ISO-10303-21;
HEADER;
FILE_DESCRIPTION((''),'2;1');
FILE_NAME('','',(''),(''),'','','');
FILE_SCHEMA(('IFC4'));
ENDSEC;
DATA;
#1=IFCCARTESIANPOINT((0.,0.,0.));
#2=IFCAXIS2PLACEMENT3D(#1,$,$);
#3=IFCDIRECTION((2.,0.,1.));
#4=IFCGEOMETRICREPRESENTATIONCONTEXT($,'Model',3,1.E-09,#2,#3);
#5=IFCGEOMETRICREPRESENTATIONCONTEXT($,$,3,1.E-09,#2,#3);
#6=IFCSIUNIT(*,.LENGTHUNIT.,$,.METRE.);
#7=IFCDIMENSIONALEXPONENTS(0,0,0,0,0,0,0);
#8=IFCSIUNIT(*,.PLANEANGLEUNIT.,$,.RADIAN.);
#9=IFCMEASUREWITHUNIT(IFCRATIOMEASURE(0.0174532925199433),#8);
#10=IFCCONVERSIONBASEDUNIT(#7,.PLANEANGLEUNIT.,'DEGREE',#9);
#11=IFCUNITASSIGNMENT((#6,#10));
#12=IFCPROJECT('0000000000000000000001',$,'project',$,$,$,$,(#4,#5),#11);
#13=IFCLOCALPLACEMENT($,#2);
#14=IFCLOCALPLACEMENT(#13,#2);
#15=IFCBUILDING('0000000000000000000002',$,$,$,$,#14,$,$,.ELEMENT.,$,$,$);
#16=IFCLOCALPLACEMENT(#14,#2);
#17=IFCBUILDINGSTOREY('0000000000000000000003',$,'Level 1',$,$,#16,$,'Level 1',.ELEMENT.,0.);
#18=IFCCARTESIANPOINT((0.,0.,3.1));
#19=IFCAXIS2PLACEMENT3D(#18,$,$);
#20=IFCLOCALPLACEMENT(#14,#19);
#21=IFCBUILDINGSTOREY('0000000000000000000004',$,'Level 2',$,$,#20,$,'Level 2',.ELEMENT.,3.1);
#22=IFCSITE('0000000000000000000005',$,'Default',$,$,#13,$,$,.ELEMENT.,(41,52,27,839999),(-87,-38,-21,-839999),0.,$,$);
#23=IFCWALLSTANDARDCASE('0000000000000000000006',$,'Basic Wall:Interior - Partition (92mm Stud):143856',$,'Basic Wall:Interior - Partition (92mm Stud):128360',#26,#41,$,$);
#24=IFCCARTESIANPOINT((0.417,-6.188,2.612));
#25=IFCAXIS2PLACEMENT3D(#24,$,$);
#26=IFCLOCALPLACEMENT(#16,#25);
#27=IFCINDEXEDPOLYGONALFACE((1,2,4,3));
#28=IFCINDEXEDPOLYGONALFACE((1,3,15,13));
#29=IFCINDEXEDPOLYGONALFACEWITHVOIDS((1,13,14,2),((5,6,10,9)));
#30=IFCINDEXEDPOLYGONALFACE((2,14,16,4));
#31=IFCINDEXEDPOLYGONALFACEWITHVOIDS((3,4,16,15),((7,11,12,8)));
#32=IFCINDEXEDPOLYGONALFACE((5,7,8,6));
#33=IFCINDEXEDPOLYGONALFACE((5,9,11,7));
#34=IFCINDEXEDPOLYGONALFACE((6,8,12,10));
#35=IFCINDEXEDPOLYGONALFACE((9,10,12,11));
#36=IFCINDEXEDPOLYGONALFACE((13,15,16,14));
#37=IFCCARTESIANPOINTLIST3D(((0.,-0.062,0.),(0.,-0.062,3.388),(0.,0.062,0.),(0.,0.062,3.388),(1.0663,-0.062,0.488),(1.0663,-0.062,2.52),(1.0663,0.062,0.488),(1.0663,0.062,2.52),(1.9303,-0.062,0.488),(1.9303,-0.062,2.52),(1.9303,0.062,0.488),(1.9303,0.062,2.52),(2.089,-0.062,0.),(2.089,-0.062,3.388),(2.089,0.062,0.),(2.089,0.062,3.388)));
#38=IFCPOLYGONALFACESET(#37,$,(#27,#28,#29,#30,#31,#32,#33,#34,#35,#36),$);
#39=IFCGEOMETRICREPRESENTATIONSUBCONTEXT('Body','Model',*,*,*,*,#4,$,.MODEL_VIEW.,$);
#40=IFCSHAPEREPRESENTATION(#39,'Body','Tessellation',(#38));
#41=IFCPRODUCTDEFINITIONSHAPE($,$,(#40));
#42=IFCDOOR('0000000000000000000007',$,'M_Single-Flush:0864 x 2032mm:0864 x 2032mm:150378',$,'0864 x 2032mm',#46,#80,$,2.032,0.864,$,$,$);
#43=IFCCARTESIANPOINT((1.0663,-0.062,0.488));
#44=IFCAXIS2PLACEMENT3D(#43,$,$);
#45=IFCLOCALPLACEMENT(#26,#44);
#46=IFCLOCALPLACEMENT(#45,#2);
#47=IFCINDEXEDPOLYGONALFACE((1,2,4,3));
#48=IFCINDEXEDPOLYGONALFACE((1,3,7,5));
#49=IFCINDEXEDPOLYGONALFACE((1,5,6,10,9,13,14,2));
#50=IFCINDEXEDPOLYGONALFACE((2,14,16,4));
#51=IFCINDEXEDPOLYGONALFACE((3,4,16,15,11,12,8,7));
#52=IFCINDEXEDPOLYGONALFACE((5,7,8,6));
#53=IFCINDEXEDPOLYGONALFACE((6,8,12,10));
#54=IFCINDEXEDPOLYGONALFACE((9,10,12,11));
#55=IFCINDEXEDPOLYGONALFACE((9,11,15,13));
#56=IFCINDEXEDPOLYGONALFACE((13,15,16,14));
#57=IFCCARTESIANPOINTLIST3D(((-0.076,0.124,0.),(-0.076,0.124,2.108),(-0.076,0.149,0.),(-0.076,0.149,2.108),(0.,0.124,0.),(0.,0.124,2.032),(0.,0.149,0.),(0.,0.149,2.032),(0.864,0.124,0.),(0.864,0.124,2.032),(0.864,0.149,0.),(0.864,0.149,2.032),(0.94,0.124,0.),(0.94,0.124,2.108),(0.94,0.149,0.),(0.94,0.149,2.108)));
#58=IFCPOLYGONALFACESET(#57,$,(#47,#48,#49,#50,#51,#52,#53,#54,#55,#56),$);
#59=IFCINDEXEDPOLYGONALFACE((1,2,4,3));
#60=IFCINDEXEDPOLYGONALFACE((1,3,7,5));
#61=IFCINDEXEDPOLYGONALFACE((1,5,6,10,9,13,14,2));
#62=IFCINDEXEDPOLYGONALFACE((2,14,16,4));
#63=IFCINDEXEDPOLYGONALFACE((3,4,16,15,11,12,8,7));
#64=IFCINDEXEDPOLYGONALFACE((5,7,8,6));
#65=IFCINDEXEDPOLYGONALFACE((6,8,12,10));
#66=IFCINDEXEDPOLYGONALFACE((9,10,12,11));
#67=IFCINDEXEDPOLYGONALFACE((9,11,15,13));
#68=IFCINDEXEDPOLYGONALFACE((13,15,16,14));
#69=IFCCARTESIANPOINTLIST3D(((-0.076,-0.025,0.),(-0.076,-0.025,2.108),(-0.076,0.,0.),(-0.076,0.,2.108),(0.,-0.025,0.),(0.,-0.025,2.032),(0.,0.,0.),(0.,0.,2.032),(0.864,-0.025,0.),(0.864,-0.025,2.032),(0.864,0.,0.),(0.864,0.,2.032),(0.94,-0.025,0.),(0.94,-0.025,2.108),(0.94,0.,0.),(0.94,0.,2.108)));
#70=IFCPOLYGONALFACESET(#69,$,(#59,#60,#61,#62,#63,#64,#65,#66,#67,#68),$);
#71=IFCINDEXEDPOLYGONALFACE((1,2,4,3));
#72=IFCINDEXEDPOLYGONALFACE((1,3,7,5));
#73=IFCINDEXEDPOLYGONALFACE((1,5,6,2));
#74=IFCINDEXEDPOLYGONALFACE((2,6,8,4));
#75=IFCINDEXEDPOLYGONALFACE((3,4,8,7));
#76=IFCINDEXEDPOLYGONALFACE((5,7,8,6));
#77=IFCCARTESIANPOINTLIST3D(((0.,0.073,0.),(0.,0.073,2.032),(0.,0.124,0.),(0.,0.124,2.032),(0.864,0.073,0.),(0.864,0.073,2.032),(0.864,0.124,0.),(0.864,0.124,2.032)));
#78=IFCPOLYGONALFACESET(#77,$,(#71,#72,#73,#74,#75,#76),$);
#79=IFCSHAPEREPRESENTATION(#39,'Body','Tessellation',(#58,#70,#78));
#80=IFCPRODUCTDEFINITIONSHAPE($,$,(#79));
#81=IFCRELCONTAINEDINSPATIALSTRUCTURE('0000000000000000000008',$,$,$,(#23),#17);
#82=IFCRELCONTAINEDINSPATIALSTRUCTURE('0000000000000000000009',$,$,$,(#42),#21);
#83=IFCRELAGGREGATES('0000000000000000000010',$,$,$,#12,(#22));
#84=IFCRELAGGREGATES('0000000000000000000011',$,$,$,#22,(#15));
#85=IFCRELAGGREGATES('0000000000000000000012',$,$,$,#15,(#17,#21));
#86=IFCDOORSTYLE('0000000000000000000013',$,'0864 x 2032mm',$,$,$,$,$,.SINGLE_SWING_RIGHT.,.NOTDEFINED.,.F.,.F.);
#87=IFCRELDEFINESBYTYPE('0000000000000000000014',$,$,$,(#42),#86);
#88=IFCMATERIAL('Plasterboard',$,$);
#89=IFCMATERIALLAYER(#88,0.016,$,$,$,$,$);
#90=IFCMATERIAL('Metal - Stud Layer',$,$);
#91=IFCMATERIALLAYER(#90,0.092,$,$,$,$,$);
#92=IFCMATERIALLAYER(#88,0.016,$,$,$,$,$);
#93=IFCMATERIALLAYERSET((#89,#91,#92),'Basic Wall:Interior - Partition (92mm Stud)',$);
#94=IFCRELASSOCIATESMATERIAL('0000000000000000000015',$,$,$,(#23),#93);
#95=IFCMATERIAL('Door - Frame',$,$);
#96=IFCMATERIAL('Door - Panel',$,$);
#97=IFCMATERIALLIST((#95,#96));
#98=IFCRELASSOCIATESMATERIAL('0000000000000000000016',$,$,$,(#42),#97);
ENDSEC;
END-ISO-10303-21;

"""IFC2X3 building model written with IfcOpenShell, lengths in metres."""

from ifc_helpers import new_model, entity, si_unit, converted_unit, direction, frame, frame_2d, origin, origin_2d_with_axis, place, context, subcontext, project, spatial, polyline, rectangle, outline, extrude, source, transform, mapped, material, material_list, layer, layer_set, layer_usage, type_object, type_shapes, element, fill, save


model = new_model("IFC2X3")

# Units and contexts
model_context = context("Model", 3, precision=1e-09, world=origin(), true_north=direction((2.0, 0.0, 1.0)))
context_of_model = context(None, 3, precision=1e-09, world=origin(), true_north=direction((2.0, 0.0, 1.0)))
body_context = subcontext(model_context, "Body", "Model", "MODEL_VIEW")
ifc_project = project(units=[si_unit("LENGTHUNIT", "METRE"), converted_unit("PLANEANGLEUNIT", "DEGREE", entity("IfcRatioMeasure", 0.0174532925199433), si_unit("PLANEANGLEUNIT", "RADIAN"), dimensions=[0, 0, 0, 0, 0, 0, 0])], contexts=[model_context, context_of_model])

# Site, building, storey
site_placement = place(None, origin())
site = spatial("IfcSite", under=ifc_project, at=site_placement, Name="Default", CompositionType="ELEMENT", RefLatitude=(41, 52, 27, 839999), RefLongitude=(-87, -38, -21, -839999), RefElevation=0.0)
building_placement = place(site_placement, origin())
building = spatial("IfcBuilding", under=site, at=building_placement, CompositionType="ELEMENT")
storey_1_placement = place(building_placement, origin())
storey_1 = spatial("IfcBuildingStorey", under=building, at=storey_1_placement, Name="Level 1", LongName="Level 1", CompositionType="ELEMENT", Elevation=0.0)

# Shared definitions
ifc_material_1 = material(Name="Metal - Stud Layer")
ifc_material_2 = material(Name="Plasterboard")
ifc_material_3 = material(Name="Door - Frame")
ifc_material_4 = material(Name="Door - Panel")

# Shared definitions
ifc_layer_1 = layer(ifc_material_2, 0.016)
ifc_layer_2 = layer(ifc_material_1, 0.092)
ifc_layer_3 = layer(ifc_material_2, 0.016)
ifc_layer_set_1 = layer_set([ifc_layer_1, ifc_layer_2, ifc_layer_3], Name="Basic Wall:Interior - Partition (92mm Stud)")

# Wall, opening
ifc_layer_usage_1 = layer_usage(ifc_layer_set_1, "AXIS2", "NEGATIVE", 0.062)
wall_1_placement = place(storey_1_placement, frame((0.417, -6.188, 2.612)))
wall_1 = element("IfcWallStandardCase", 1, at=wall_1_placement, inside=storey_1, material=ifc_layer_usage_1, Name="Basic Wall:Interior - Partition (92mm Stud):143856", ObjectType="Basic Wall:Interior - Partition (92mm Stud):128360", context=body_context, shape_type="SweptSolid", body=[
    extrude(rectangle(XDim=2.089, YDim=0.124, at=frame_2d((1.0445, 0.0), x_axis=(-1.0, 0.0))), origin(), (0.0, 0.0, 1.0), 3.388),
])
opening_1_placement = place(wall_1_placement, frame((1.0663, -0.062, 0.488)))
opening_1 = element("IfcOpeningElement", 2, at=opening_1_placement, cuts=wall_1, ObjectType="Opening", context=body_context, shape_type="SweptSolid", body=[
    extrude(rectangle(XDim=0.864, YDim=2.032, at=frame_2d((1.016, 0.432), x_axis=(0.0, 1.0))), frame((0.0, 0.0, 0.0), z_axis=(0.0, 1.0, 0.0), x_axis=(0.0, 0.0, 1.0)), (0.0, 0.0, 1.0), 0.124),
])

# Shared definitions
storey_2_placement = place(building_placement, frame((0.0, 0.0, 3.1)))
storey_2 = spatial("IfcBuildingStorey", under=building, at=storey_2_placement, Name="Level 2", LongName="Level 2", CompositionType="ELEMENT", Elevation=3.1)

# Door
ifc_material_list_1 = material_list([ifc_material_3, ifc_material_4])
door_style_1 = type_object("IfcDoorStyle", Name="0864 x 2032mm", ConstructionType="NOTDEFINED", OperationType="SINGLE_SWING_RIGHT", ParameterTakesPrecedence=False, Sizeable=False)
shared_shape_1 = source(origin(), body_context, "Body", "SweptSolid", [
    extrude(outline(polyline([(-0.508, -1.073), (0.508, -1.073), (0.508, 1.035), (0.432, 1.035), (0.432, -0.997), (-0.432, -0.997), (-0.432, 1.035), (-0.508, 1.035), (-0.508, -1.073)])), frame((0.432, 0.124, 1.035), z_axis=(0.0, 1.0, 0.0), x_axis=(1.0, 0.0, 0.0)), (0.0, 0.0, 1.0), 0.025),
    extrude(outline(polyline([(-1.073, -0.508), (1.035, -0.508), (1.035, -0.432), (-0.997, -0.432), (-0.997, 0.432), (1.035, 0.432), (1.035, 0.508), (-1.073, 0.508), (-1.073, -0.508)])), frame((0.432, -0.025, 1.035), z_axis=(0.0, 1.0, 0.0), x_axis=(0.0, 0.0, -1.0)), (0.0, 0.0, 1.0), 0.025),
    extrude(rectangle(XDim=0.051, YDim=0.864, at=origin_2d_with_axis()), frame((0.432, 0.0985, 0.0), z_axis=(0.0, 0.0, 1.0), x_axis=(0.0, 1.0, 0.0)), (0.0, 0.0, 1.0), 2.032),
])
type_shapes(door_style_1, [shared_shape_1])
door_1_placement = place(opening_1_placement, origin())
door_1 = element("IfcDoor", 3, at=door_1_placement, inside=storey_2, type_object=door_style_1, material=ifc_material_list_1, Name="M_Single-Flush:0864 x 2032mm:0864 x 2032mm:150378", ObjectType="0864 x 2032mm", OverallHeight=2.032, OverallWidth=0.864, context=body_context, shape_type="MappedRepresentation", body=[
    mapped(shared_shape_1, transform((0.0, 0.0, 0.0), scale=1.0)),
])
fill(opening_1, door_1)

save(model, "model.ifc")
